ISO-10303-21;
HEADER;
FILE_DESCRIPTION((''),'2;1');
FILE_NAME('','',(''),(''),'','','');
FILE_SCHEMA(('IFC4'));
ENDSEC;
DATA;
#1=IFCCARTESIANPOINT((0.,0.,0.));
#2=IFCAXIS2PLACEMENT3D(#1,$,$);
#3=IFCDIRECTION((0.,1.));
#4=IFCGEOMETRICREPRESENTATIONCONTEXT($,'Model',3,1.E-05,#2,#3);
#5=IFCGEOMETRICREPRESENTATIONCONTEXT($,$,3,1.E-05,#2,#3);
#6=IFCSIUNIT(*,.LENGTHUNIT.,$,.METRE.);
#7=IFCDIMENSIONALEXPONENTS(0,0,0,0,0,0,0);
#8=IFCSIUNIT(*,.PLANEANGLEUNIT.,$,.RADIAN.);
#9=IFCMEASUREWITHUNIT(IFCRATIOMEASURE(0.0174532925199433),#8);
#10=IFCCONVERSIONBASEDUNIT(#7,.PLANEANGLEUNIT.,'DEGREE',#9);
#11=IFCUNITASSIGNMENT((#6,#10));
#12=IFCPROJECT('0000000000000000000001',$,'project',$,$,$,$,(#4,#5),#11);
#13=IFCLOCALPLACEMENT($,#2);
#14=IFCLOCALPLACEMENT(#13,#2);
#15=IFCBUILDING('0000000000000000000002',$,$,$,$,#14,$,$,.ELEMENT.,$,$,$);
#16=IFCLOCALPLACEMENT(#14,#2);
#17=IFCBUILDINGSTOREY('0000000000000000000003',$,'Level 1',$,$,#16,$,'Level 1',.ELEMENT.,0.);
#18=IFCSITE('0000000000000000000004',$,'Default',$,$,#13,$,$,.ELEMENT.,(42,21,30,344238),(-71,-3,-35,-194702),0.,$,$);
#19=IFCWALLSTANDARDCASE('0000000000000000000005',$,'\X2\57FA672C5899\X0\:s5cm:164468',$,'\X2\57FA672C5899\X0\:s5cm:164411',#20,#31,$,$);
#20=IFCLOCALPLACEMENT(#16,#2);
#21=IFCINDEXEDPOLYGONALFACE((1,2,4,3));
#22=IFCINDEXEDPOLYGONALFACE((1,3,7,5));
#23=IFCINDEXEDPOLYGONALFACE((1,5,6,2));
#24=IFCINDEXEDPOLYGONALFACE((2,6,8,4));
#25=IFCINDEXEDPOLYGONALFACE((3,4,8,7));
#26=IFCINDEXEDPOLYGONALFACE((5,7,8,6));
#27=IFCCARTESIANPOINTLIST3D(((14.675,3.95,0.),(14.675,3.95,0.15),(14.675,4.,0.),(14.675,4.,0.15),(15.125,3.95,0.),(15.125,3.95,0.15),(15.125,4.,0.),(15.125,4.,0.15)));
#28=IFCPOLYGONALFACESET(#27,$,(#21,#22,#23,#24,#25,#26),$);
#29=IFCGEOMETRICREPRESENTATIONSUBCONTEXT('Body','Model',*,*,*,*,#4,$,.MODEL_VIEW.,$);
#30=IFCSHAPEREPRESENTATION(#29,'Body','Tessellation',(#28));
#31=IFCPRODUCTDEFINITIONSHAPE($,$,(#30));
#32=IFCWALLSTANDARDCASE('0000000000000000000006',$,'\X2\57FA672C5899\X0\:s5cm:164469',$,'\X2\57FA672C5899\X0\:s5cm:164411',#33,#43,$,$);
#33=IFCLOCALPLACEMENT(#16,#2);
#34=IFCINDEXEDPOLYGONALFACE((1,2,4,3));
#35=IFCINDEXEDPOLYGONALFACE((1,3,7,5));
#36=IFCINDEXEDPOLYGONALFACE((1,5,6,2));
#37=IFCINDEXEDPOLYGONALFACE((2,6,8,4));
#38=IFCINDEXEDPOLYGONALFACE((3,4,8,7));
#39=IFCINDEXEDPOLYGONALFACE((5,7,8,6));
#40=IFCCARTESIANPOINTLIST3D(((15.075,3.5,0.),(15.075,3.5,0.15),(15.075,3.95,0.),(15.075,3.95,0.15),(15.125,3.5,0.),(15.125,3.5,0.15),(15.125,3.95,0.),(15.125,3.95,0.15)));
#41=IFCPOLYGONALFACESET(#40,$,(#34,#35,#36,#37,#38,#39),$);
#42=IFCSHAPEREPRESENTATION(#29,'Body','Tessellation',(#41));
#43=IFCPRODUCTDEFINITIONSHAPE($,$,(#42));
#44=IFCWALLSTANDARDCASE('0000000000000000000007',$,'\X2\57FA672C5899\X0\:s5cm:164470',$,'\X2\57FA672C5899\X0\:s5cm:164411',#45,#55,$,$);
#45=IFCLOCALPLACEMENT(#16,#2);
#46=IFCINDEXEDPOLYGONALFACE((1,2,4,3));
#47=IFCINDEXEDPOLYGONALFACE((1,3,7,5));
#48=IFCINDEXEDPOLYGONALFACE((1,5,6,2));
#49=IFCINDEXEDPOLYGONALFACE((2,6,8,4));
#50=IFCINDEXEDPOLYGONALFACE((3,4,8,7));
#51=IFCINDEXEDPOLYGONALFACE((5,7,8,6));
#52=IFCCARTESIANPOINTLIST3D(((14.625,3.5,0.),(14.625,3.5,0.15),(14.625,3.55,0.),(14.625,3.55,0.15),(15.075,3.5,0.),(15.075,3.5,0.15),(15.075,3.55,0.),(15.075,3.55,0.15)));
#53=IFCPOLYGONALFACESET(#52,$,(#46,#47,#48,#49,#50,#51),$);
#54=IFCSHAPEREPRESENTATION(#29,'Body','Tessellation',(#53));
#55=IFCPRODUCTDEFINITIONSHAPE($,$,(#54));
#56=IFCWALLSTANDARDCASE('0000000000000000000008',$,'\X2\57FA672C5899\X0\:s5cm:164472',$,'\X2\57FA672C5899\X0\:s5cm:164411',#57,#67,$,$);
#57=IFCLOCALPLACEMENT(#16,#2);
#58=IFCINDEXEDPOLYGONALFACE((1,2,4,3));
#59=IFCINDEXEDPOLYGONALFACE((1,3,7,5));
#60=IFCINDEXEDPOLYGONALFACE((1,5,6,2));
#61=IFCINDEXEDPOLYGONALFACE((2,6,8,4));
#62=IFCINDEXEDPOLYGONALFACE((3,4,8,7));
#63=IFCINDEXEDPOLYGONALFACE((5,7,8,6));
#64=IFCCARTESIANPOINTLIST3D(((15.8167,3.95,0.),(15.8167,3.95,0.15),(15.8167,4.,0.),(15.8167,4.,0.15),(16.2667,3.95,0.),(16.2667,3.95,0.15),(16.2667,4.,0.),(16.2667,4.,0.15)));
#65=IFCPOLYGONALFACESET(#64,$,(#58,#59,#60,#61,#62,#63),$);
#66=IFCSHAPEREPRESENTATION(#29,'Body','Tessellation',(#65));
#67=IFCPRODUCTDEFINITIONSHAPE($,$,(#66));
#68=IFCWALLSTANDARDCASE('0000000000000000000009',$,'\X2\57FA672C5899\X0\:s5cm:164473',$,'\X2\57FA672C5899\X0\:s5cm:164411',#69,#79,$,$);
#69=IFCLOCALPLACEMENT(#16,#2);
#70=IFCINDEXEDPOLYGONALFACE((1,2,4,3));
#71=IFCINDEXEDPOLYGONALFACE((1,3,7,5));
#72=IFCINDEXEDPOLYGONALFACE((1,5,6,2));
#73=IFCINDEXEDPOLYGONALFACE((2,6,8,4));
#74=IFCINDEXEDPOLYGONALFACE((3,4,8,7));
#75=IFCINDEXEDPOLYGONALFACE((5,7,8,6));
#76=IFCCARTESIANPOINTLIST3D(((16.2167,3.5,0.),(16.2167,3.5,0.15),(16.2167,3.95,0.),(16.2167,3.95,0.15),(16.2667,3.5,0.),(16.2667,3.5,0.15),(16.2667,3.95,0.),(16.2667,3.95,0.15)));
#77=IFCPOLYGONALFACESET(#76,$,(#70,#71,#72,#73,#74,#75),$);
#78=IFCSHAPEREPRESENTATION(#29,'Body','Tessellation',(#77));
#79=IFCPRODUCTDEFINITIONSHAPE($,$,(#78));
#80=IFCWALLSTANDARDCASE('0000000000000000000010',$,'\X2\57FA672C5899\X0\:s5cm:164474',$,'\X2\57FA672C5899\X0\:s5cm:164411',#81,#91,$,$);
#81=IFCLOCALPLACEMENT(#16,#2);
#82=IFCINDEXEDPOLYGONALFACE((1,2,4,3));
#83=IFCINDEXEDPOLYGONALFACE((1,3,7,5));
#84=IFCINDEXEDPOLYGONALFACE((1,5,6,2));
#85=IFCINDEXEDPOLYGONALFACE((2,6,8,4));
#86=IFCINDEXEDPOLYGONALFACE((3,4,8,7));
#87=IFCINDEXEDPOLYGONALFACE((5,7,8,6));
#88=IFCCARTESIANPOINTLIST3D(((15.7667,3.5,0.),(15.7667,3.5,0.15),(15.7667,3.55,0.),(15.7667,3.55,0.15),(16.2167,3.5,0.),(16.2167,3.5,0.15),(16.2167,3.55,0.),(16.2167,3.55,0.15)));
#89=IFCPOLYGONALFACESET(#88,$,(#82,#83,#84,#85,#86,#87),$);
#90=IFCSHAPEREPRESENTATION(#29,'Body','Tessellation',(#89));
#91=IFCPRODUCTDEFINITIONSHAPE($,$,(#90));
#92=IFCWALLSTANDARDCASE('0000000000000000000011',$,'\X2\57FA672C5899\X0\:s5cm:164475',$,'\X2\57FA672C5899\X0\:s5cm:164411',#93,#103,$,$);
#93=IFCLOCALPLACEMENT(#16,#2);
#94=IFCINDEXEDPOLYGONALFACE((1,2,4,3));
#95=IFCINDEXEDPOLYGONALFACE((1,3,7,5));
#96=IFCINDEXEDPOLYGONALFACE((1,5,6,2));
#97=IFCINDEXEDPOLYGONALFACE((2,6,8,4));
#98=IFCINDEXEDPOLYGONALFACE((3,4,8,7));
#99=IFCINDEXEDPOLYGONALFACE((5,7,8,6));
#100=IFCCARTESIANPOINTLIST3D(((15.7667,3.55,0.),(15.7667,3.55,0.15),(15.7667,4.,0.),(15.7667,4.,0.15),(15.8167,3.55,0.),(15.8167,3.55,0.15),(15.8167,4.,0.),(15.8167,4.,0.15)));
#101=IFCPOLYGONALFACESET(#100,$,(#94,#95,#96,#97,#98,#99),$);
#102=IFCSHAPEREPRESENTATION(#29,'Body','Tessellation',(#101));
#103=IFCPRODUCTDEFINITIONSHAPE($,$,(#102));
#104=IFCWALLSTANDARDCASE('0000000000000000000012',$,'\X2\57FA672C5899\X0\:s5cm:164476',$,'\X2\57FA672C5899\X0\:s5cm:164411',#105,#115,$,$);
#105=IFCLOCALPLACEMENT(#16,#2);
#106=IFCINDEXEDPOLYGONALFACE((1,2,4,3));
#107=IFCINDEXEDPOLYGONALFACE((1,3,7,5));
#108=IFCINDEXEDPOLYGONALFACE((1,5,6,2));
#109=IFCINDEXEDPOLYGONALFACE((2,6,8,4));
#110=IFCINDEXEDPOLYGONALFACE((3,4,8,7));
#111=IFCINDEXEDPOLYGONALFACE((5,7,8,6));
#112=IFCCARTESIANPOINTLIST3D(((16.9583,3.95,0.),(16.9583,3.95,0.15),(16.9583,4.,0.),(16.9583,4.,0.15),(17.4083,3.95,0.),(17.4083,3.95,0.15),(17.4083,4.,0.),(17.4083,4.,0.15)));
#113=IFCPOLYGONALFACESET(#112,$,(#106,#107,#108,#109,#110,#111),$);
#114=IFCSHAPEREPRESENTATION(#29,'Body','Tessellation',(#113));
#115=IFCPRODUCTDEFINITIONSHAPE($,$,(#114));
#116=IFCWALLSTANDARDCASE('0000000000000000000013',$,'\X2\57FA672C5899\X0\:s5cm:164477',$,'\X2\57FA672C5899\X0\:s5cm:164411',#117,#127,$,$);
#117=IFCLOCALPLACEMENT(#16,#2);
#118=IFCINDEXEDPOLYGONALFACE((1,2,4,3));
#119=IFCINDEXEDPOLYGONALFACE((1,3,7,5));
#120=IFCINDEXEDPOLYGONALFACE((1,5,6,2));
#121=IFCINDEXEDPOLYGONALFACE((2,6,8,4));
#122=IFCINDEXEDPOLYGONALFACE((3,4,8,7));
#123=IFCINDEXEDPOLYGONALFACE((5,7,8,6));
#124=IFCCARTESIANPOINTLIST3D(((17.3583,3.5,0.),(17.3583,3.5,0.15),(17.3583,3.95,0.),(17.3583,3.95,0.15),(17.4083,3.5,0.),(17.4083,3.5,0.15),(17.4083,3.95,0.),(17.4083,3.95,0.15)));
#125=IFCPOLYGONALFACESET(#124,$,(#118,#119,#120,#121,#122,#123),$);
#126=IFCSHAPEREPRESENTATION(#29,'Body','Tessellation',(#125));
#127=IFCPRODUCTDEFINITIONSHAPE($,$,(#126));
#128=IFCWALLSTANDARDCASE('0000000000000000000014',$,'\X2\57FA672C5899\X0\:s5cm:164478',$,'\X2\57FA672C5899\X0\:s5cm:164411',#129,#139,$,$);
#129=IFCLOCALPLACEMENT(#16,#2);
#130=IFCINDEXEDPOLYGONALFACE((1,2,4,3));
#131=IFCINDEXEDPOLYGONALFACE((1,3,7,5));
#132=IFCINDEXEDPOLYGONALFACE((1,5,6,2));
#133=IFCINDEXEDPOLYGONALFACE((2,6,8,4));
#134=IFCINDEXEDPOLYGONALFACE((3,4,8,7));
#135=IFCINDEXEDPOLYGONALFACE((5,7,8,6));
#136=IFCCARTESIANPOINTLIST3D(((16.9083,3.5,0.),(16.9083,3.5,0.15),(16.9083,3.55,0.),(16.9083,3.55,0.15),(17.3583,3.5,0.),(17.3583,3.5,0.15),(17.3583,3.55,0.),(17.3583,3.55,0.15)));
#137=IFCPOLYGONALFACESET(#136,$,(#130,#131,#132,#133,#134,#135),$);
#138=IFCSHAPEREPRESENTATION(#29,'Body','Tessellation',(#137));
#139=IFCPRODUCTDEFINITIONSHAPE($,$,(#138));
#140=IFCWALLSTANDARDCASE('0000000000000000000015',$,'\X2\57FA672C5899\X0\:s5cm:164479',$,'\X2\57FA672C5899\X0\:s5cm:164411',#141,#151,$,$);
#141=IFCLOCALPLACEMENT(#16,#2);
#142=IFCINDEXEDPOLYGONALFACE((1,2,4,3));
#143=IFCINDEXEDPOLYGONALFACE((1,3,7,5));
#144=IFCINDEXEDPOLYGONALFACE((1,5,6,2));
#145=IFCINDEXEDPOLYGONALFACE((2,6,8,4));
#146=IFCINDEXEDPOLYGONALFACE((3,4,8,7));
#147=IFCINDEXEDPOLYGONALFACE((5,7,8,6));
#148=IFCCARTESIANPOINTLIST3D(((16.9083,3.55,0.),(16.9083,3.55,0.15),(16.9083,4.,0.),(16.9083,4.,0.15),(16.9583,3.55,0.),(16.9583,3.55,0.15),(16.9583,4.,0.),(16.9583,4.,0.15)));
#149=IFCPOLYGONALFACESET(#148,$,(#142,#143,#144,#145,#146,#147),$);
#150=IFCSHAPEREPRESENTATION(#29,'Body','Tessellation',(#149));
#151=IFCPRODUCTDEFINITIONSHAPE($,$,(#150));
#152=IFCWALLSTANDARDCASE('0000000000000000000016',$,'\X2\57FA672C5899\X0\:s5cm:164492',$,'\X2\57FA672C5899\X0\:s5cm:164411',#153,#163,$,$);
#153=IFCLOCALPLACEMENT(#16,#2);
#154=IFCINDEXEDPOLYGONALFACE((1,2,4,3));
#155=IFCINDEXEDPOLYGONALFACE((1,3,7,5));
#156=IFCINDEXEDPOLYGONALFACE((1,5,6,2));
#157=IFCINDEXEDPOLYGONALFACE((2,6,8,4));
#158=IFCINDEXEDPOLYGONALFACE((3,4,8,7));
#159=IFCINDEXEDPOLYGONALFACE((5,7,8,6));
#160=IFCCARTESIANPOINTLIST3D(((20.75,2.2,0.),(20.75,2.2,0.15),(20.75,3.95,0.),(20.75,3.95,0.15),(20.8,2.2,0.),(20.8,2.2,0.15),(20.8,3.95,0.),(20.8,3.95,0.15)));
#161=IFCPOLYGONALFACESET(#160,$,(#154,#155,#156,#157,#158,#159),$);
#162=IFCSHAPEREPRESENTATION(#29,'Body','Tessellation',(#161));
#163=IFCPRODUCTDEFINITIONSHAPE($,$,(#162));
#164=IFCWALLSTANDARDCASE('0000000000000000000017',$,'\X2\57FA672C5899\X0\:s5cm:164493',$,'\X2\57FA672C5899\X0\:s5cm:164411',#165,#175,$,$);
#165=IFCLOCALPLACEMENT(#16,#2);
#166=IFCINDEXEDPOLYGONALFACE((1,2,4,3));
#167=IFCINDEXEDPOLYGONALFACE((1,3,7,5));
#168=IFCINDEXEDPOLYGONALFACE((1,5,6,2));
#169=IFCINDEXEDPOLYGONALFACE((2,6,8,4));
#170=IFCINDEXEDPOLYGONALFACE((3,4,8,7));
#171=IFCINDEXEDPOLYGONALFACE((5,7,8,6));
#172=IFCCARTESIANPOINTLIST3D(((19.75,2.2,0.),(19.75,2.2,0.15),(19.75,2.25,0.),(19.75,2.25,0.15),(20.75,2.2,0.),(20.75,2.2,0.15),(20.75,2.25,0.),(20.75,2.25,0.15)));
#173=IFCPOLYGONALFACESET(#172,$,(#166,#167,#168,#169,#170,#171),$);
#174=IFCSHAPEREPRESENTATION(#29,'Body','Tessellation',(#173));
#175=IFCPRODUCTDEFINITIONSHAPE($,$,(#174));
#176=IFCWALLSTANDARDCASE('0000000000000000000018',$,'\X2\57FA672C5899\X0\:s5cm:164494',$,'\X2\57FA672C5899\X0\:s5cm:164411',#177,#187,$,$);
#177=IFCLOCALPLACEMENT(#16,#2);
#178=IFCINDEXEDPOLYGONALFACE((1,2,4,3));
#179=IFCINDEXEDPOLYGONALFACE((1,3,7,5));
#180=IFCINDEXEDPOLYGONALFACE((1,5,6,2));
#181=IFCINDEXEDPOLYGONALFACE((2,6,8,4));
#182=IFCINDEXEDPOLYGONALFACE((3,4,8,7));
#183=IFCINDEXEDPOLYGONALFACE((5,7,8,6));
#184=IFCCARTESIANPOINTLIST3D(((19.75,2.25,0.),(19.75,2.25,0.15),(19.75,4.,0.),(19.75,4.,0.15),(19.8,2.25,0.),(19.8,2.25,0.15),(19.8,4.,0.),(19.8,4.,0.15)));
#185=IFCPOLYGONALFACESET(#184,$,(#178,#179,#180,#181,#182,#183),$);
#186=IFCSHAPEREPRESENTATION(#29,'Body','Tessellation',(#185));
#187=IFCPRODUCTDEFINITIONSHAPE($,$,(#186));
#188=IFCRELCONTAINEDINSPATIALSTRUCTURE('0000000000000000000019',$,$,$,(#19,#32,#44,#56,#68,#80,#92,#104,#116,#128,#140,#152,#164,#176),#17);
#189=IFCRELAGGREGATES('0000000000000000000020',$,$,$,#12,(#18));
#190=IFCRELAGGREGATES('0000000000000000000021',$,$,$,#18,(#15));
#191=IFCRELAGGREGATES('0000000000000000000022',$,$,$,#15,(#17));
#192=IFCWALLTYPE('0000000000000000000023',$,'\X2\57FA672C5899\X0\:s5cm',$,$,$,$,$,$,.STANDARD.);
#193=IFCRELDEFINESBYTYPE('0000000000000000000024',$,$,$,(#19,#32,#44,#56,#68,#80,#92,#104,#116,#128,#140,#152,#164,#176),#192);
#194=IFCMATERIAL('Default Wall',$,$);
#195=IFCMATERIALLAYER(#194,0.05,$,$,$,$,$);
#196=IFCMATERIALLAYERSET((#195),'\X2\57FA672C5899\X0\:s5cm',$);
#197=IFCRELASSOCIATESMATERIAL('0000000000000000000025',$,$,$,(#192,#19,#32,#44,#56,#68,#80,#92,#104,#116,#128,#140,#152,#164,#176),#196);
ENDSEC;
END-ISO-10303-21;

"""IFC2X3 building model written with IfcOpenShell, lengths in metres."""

from ifc_helpers import new_model, entity, si_unit, converted_unit, direction, frame, frame_2d, origin, place, context, subcontext, project, spatial, rectangle, extrude, material, layer, layer_set, layer_usage, type_object, element, save


model = new_model("IFC2X3")

# Units and contexts
model_context = context("Model", 3, precision=1e-05, world=origin(), true_north=direction((0.0, 1.0)))
context_of_model = context(None, 3, precision=1e-05, world=origin(), true_north=direction((0.0, 1.0)))
body_context = subcontext(model_context, "Body", "Model", "MODEL_VIEW")
ifc_project = project(units=[si_unit("LENGTHUNIT", "METRE"), converted_unit("PLANEANGLEUNIT", "DEGREE", entity("IfcRatioMeasure", 0.0174532925199433), si_unit("PLANEANGLEUNIT", "RADIAN"), dimensions=[0, 0, 0, 0, 0, 0, 0])], contexts=[model_context, context_of_model])

# Site, building, storey
site_placement = place(None, origin())
site = spatial("IfcSite", under=ifc_project, at=site_placement, Name="Default", CompositionType="ELEMENT", RefLatitude=(42, 21, 30, 344238), RefLongitude=(-71, -3, -35, -194702), RefElevation=0.0)
building_placement = place(site_placement, origin())
building = spatial("IfcBuilding", under=site, at=building_placement, CompositionType="ELEMENT")
storey_placement = place(building_placement, origin())
storey = spatial("IfcBuildingStorey", under=building, at=storey_placement, Name="Level 1", LongName="Level 1", CompositionType="ELEMENT", Elevation=0.0)

# Walls
ifc_material_1 = material(Name="Default Wall")
ifc_layer_1 = layer(ifc_material_1, 0.05)
ifc_layer_set_1 = layer_set([ifc_layer_1], Name="基本墙:s5cm")
ifc_layer_usage_1 = layer_usage(ifc_layer_set_1, "AXIS2", "NEGATIVE", 0.025)
wall_type = type_object("IfcWallType", Name="基本墙:s5cm", PredefinedType="STANDARD", material=ifc_layer_set_1)
wall_1_placement = place(storey_placement, frame((14.675, 3.975, 0.0)))
element("IfcWallStandardCase", 1, at=wall_1_placement, inside=storey, type_object=wall_type, material=ifc_layer_usage_1, Name="基本墙:s5cm:164468", ObjectType="基本墙:s5cm:164411", context=body_context, shape_type="SweptSolid", body=[
    extrude(rectangle(XDim=0.45, YDim=0.05, at=frame_2d((0.225, 0.0), x_axis=(-1.0, 0.0))), origin(), (0.0, 0.0, 1.0), 0.15),
])
ifc_layer_usage_2 = layer_usage(ifc_layer_set_1, "AXIS2", "NEGATIVE", 0.025)
wall_2_placement = place(storey_placement, frame((15.1, 3.95, 0.0), z_axis=(0.0, 0.0, 1.0), x_axis=(0.0, -1.0, 0.0)))
element("IfcWallStandardCase", 2, at=wall_2_placement, inside=storey, type_object=wall_type, material=ifc_layer_usage_2, Name="基本墙:s5cm:164469", ObjectType="基本墙:s5cm:164411", context=body_context, shape_type="SweptSolid", body=[
    extrude(rectangle(XDim=0.45, YDim=0.05, at=frame_2d((0.225, 0.0), x_axis=(-1.0, 0.0))), origin(), (0.0, 0.0, 1.0), 0.15),
])
ifc_layer_usage_3 = layer_usage(ifc_layer_set_1, "AXIS2", "NEGATIVE", 0.025)
wall_3_placement = place(storey_placement, frame((15.075, 3.525, 0.0), z_axis=(0.0, 0.0, 1.0), x_axis=(-1.0, 0.0, 0.0)))
element("IfcWallStandardCase", 3, at=wall_3_placement, inside=storey, type_object=wall_type, material=ifc_layer_usage_3, Name="基本墙:s5cm:164470", ObjectType="基本墙:s5cm:164411", context=body_context, shape_type="SweptSolid", body=[
    extrude(rectangle(XDim=0.45, YDim=0.05, at=frame_2d((0.225, 0.0), x_axis=(-1.0, 0.0))), origin(), (0.0, 0.0, 1.0), 0.15),
])
ifc_layer_usage_4 = layer_usage(ifc_layer_set_1, "AXIS2", "NEGATIVE", 0.025)
wall_4_placement = place(storey_placement, frame((15.8167, 3.975, 0.0)))
element("IfcWallStandardCase", 4, at=wall_4_placement, inside=storey, type_object=wall_type, material=ifc_layer_usage_4, Name="基本墙:s5cm:164472", ObjectType="基本墙:s5cm:164411", context=body_context, shape_type="SweptSolid", body=[
    extrude(rectangle(XDim=0.45, YDim=0.05, at=frame_2d((0.225, 0.0), x_axis=(-1.0, 0.0))), origin(), (0.0, 0.0, 1.0), 0.15),
])
ifc_layer_usage_5 = layer_usage(ifc_layer_set_1, "AXIS2", "NEGATIVE", 0.025)
wall_5_placement = place(storey_placement, frame((16.2417, 3.95, 0.0), z_axis=(0.0, 0.0, 1.0), x_axis=(0.0, -1.0, 0.0)))
element("IfcWallStandardCase", 5, at=wall_5_placement, inside=storey, type_object=wall_type, material=ifc_layer_usage_5, Name="基本墙:s5cm:164473", ObjectType="基本墙:s5cm:164411", context=body_context, shape_type="SweptSolid", body=[
    extrude(rectangle(XDim=0.45, YDim=0.05, at=frame_2d((0.225, 0.0), x_axis=(-1.0, 0.0))), origin(), (0.0, 0.0, 1.0), 0.15),
])
ifc_layer_usage_6 = layer_usage(ifc_layer_set_1, "AXIS2", "NEGATIVE", 0.025)
wall_6_placement = place(storey_placement, frame((16.2167, 3.525, 0.0), z_axis=(0.0, 0.0, 1.0), x_axis=(-1.0, 0.0, 0.0)))
element("IfcWallStandardCase", 6, at=wall_6_placement, inside=storey, type_object=wall_type, material=ifc_layer_usage_6, Name="基本墙:s5cm:164474", ObjectType="基本墙:s5cm:164411", context=body_context, shape_type="SweptSolid", body=[
    extrude(rectangle(XDim=0.45, YDim=0.05, at=frame_2d((0.225, 0.0), x_axis=(-1.0, 0.0))), origin(), (0.0, 0.0, 1.0), 0.15),
])
ifc_layer_usage_7 = layer_usage(ifc_layer_set_1, "AXIS2", "NEGATIVE", 0.025)
wall_7_placement = place(storey_placement, frame((15.7917, 3.55, 0.0), z_axis=(0.0, 0.0, 1.0), x_axis=(0.0, 1.0, 0.0)))
element("IfcWallStandardCase", 7, at=wall_7_placement, inside=storey, type_object=wall_type, material=ifc_layer_usage_7, Name="基本墙:s5cm:164475", ObjectType="基本墙:s5cm:164411", context=body_context, shape_type="SweptSolid", body=[
    extrude(rectangle(XDim=0.45, YDim=0.05, at=frame_2d((0.225, 0.0), x_axis=(-1.0, 0.0))), origin(), (0.0, 0.0, 1.0), 0.15),
])
ifc_layer_usage_8 = layer_usage(ifc_layer_set_1, "AXIS2", "NEGATIVE", 0.025)
wall_8_placement = place(storey_placement, frame((16.9583, 3.975, 0.0)))
element("IfcWallStandardCase", 8, at=wall_8_placement, inside=storey, type_object=wall_type, material=ifc_layer_usage_8, Name="基本墙:s5cm:164476", ObjectType="基本墙:s5cm:164411", context=body_context, shape_type="SweptSolid", body=[
    extrude(rectangle(XDim=0.45, YDim=0.05, at=frame_2d((0.225, 0.0), x_axis=(-1.0, 0.0))), origin(), (0.0, 0.0, 1.0), 0.15),
])
ifc_layer_usage_9 = layer_usage(ifc_layer_set_1, "AXIS2", "NEGATIVE", 0.025)
wall_9_placement = place(storey_placement, frame((17.3833, 3.95, 0.0), z_axis=(0.0, 0.0, 1.0), x_axis=(0.0, -1.0, 0.0)))
element("IfcWallStandardCase", 9, at=wall_9_placement, inside=storey, type_object=wall_type, material=ifc_layer_usage_9, Name="基本墙:s5cm:164477", ObjectType="基本墙:s5cm:164411", context=body_context, shape_type="SweptSolid", body=[
    extrude(rectangle(XDim=0.45, YDim=0.05, at=frame_2d((0.225, 0.0), x_axis=(-1.0, 0.0))), origin(), (0.0, 0.0, 1.0), 0.15),
])
ifc_layer_usage_10 = layer_usage(ifc_layer_set_1, "AXIS2", "NEGATIVE", 0.025)
wall_10_placement = place(storey_placement, frame((17.3583, 3.525, 0.0), z_axis=(0.0, 0.0, 1.0), x_axis=(-1.0, 0.0, 0.0)))
element("IfcWallStandardCase", 10, at=wall_10_placement, inside=storey, type_object=wall_type, material=ifc_layer_usage_10, Name="基本墙:s5cm:164478", ObjectType="基本墙:s5cm:164411", context=body_context, shape_type="SweptSolid", body=[
    extrude(rectangle(XDim=0.45, YDim=0.05, at=frame_2d((0.225, 0.0), x_axis=(-1.0, 0.0))), origin(), (0.0, 0.0, 1.0), 0.15),
])
ifc_layer_usage_11 = layer_usage(ifc_layer_set_1, "AXIS2", "NEGATIVE", 0.025)
wall_11_placement = place(storey_placement, frame((16.9333, 3.55, 0.0), z_axis=(0.0, 0.0, 1.0), x_axis=(0.0, 1.0, 0.0)))
element("IfcWallStandardCase", 11, at=wall_11_placement, inside=storey, type_object=wall_type, material=ifc_layer_usage_11, Name="基本墙:s5cm:164479", ObjectType="基本墙:s5cm:164411", context=body_context, shape_type="SweptSolid", body=[
    extrude(rectangle(XDim=0.45, YDim=0.05, at=frame_2d((0.225, 0.0), x_axis=(-1.0, 0.0))), origin(), (0.0, 0.0, 1.0), 0.15),
])
ifc_layer_usage_12 = layer_usage(ifc_layer_set_1, "AXIS2", "NEGATIVE", 0.025)
wall_12_placement = place(storey_placement, frame((20.775, 3.95, 0.0), z_axis=(0.0, 0.0, 1.0), x_axis=(0.0, -1.0, 0.0)))
element("IfcWallStandardCase", 12, at=wall_12_placement, inside=storey, type_object=wall_type, material=ifc_layer_usage_12, Name="基本墙:s5cm:164492", ObjectType="基本墙:s5cm:164411", context=body_context, shape_type="SweptSolid", body=[
    extrude(rectangle(XDim=1.75, YDim=0.05, at=frame_2d((0.875, 0.0), x_axis=(-1.0, 0.0))), origin(), (0.0, 0.0, 1.0), 0.15),
])
ifc_layer_usage_13 = layer_usage(ifc_layer_set_1, "AXIS2", "NEGATIVE", 0.025)
wall_13_placement = place(storey_placement, frame((20.75, 2.225, 0.0), z_axis=(0.0, 0.0, 1.0), x_axis=(-1.0, 0.0, 0.0)))
element("IfcWallStandardCase", 13, at=wall_13_placement, inside=storey, type_object=wall_type, material=ifc_layer_usage_13, Name="基本墙:s5cm:164493", ObjectType="基本墙:s5cm:164411", context=body_context, shape_type="SweptSolid", body=[
    extrude(rectangle(XDim=1.0, YDim=0.05, at=frame_2d((0.5, 0.0), x_axis=(-1.0, 0.0))), origin(), (0.0, 0.0, 1.0), 0.15),
])
ifc_layer_usage_14 = layer_usage(ifc_layer_set_1, "AXIS2", "NEGATIVE", 0.025)
wall_14_placement = place(storey_placement, frame((19.775, 2.25, 0.0), z_axis=(0.0, 0.0, 1.0), x_axis=(0.0, 1.0, 0.0)))
element("IfcWallStandardCase", 14, at=wall_14_placement, inside=storey, type_object=wall_type, material=ifc_layer_usage_14, Name="基本墙:s5cm:164494", ObjectType="基本墙:s5cm:164411", context=body_context, shape_type="SweptSolid", body=[
    extrude(rectangle(XDim=1.75, YDim=0.05, at=frame_2d((0.875, 0.0), x_axis=(-1.0, 0.0))), origin(), (0.0, 0.0, 1.0), 0.15),
])

save(model, "model.ifc")
